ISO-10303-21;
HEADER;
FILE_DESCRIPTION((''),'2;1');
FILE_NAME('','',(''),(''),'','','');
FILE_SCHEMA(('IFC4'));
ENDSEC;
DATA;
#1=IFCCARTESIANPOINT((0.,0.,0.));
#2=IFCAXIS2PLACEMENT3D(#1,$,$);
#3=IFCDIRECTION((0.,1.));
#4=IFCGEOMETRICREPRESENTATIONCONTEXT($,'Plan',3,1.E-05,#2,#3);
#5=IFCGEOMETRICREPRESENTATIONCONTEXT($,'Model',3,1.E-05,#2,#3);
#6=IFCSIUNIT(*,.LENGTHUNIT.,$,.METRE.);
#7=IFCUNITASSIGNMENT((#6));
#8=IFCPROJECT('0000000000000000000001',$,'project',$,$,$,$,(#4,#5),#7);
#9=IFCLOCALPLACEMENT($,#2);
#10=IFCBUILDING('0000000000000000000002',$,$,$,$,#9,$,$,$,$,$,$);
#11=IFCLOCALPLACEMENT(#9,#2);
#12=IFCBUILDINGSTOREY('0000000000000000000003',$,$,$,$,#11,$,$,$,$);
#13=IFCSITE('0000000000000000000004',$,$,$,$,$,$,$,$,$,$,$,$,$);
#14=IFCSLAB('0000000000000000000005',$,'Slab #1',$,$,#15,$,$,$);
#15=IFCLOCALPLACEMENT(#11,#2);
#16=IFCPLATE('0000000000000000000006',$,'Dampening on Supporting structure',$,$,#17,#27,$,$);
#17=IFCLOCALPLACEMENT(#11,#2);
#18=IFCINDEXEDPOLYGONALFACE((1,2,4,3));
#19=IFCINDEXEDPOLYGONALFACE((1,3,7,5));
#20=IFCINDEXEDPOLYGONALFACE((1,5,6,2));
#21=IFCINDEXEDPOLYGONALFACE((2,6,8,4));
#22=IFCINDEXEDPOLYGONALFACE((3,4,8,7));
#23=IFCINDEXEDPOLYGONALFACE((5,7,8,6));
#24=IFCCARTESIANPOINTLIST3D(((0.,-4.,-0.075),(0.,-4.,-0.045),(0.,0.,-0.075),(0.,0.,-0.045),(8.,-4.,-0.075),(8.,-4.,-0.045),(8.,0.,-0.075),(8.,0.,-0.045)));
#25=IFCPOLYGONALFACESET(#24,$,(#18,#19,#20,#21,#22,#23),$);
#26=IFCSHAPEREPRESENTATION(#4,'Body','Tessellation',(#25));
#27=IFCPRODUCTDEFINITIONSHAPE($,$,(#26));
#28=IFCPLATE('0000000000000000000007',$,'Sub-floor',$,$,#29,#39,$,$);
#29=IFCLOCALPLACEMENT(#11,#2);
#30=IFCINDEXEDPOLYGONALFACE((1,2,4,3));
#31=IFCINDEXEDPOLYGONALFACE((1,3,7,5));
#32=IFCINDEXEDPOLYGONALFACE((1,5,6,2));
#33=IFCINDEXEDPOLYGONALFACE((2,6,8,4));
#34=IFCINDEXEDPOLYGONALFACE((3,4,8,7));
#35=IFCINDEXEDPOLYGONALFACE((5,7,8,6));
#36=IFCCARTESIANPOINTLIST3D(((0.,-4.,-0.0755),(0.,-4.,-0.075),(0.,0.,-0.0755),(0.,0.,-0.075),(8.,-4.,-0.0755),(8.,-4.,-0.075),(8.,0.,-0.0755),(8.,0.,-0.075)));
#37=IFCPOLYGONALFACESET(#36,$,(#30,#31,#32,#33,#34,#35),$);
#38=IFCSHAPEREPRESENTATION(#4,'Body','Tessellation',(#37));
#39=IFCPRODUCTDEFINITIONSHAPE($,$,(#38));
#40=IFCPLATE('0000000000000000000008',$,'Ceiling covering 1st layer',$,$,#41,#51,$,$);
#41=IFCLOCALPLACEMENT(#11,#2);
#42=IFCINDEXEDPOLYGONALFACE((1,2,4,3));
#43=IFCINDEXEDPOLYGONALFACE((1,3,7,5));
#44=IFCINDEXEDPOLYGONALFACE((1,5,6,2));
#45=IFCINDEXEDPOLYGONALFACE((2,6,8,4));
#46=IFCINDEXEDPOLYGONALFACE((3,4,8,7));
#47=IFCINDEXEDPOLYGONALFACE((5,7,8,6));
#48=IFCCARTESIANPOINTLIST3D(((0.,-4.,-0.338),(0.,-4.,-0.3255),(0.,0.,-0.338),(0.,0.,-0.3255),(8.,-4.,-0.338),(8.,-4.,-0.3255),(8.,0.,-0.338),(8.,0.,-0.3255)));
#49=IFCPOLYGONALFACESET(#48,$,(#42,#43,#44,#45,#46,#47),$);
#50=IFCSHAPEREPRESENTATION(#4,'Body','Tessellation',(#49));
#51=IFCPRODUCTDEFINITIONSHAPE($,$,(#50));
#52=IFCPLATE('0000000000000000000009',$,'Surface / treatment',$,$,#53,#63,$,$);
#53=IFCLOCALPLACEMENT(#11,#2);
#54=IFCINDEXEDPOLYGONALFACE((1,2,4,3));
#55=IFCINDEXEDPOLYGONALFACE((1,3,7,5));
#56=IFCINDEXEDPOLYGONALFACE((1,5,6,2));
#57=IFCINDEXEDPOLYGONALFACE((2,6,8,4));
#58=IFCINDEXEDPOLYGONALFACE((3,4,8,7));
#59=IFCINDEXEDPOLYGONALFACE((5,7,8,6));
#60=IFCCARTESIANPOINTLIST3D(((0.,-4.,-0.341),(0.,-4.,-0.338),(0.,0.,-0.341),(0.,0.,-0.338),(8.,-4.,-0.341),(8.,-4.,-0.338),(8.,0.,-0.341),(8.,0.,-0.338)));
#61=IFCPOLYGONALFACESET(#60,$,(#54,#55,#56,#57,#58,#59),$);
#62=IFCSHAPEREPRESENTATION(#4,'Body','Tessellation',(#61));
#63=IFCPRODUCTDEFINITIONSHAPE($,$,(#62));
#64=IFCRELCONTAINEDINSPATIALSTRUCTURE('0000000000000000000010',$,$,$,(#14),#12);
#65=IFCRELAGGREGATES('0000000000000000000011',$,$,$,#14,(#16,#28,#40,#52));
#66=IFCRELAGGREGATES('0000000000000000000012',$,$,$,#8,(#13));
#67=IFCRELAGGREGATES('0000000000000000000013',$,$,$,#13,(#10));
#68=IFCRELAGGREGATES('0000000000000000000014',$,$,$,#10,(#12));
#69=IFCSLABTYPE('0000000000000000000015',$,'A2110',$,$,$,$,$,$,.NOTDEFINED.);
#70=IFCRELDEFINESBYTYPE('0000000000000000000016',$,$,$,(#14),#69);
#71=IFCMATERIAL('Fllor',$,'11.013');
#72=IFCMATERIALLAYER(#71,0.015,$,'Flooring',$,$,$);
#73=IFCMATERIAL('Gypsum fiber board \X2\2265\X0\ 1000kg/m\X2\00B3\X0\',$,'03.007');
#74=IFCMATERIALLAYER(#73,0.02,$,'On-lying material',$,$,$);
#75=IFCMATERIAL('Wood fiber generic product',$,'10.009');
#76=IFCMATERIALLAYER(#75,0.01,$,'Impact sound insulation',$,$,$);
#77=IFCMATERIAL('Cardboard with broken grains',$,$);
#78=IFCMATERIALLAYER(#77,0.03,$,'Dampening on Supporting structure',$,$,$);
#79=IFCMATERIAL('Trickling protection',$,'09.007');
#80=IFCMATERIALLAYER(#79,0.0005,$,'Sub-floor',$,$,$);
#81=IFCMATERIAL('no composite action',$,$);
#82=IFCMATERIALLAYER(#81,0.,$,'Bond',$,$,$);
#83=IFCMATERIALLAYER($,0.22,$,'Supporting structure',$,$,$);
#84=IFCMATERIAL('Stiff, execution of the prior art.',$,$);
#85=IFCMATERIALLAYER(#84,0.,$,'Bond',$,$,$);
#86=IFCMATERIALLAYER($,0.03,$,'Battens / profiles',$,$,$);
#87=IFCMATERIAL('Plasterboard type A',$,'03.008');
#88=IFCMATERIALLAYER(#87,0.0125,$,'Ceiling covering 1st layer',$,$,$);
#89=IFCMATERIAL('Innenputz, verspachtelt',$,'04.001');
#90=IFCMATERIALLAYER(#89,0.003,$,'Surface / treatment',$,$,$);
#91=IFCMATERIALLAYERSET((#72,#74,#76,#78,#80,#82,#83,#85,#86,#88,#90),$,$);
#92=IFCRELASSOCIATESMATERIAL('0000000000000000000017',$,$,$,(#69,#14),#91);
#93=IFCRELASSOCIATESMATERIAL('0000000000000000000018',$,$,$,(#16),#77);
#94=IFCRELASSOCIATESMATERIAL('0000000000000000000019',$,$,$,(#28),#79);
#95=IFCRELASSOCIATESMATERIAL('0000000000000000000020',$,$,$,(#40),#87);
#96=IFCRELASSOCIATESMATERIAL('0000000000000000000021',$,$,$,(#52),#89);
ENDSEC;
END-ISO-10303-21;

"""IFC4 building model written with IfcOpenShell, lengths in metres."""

from ifc_helpers import new_model, si_unit, direction, frame, frame_2d, origin, place, context, project, spatial, rectangle, extrude, material, layer, layer_set, type_object, element, aggregate, save


model = new_model("IFC4")

# Units and contexts
plan_context = context("Plan", 3, precision=1e-05, world=origin(), true_north=direction((0.0, 1.0)))
model_context = context("Model", 3, precision=1e-05, world=origin(), true_north=direction((0.0, 1.0)))
ifc_project = project(units=[si_unit("LENGTHUNIT", "METRE")], contexts=[plan_context, model_context])

# Site, building, storey
site = spatial("IfcSite", under=ifc_project)
building_placement = place(None, origin())
building = spatial("IfcBuilding", under=site, at=building_placement)
storey_placement = place(building_placement, origin())
storey = spatial("IfcBuildingStorey", under=building, at=storey_placement)

# Slab, plates
ifc_material_1 = material(Name="Fllor", Category="11.013")
ifc_layer_1 = layer(ifc_material_1, 0.015, Name="Flooring")
ifc_material_2 = material(Name="Gypsum fiber board ≥ 1000kg/m³", Category="03.007")
ifc_layer_2 = layer(ifc_material_2, 0.02, Name="On-lying material")
ifc_material_3 = material(Name="Wood fiber generic product", Category="10.009")
ifc_layer_3 = layer(ifc_material_3, 0.01, Name="Impact sound insulation")
ifc_material_4 = material(Name="Cardboard with broken grains")
ifc_layer_4 = layer(ifc_material_4, 0.03, Name="Dampening on Supporting structure")
ifc_material_5 = material(Name="Trickling protection", Category="09.007")
ifc_layer_5 = layer(ifc_material_5, 0.0005, Name="Sub-floor")
ifc_material_6 = material(Name="no composite action")
ifc_layer_6 = layer(ifc_material_6, 0.0, Name="Bond")
ifc_layer_7 = layer(None, 0.22, Name="Supporting structure")
ifc_material_7 = material(Name="Stiff, execution of the prior art.")
ifc_layer_8 = layer(ifc_material_7, 0.0, Name="Bond")
ifc_layer_9 = layer(None, 0.03, Name="Battens / profiles")
ifc_material_8 = material(Name="Plasterboard type A", Category="03.008")
ifc_layer_10 = layer(ifc_material_8, 0.0125, Name="Ceiling covering 1st layer")
ifc_material_9 = material(Name="Innenputz, verspachtelt", Category="04.001")
ifc_layer_11 = layer(ifc_material_9, 0.003, Name="Surface / treatment")
ifc_layer_set = layer_set([ifc_layer_1, ifc_layer_2, ifc_layer_3, ifc_layer_4, ifc_layer_5, ifc_layer_6, ifc_layer_7, ifc_layer_8, ifc_layer_9, ifc_layer_10, ifc_layer_11])
slab_type = type_object("IfcSlabType", Name="A2110", PredefinedType="NOTDEFINED", material=ifc_layer_set)
slab_placement = place(None, frame((0.0, 0.0, 0.0), z_axis=(0.0, 0.0, -1.0), x_axis=(1.0, 0.0, 0.0)))
slab = element("IfcSlab", 1, at=slab_placement, inside=storey, type_object=slab_type, material=ifc_layer_set, Name="Slab #1")
plate_1_placement = place(slab_placement, origin())
plate_1 = element("IfcPlate", 2, at=plate_1_placement, material=ifc_material_4, Name="Dampening on Supporting structure", context=plan_context, shape_type="SweptSolid", body=[
    extrude(rectangle(XDim=8.0, YDim=4.0, at=frame_2d((4.0, 2.0), x_axis=(1.0, 0.0))), frame((0.0, 0.0, 0.045), z_axis=(0.0, 0.0, 1.0), x_axis=(1.0, 0.0, 0.0)), (0.0, 0.0, 1.0), 0.03),
])
plate_2_placement = place(slab_placement, origin())
plate_2 = element("IfcPlate", 3, at=plate_2_placement, material=ifc_material_5, Name="Sub-floor", context=plan_context, shape_type="SweptSolid", body=[
    extrude(rectangle(XDim=8.0, YDim=4.0, at=frame_2d((4.0, 2.0), x_axis=(1.0, 0.0))), frame((0.0, 0.0, 0.075), z_axis=(0.0, 0.0, 1.0), x_axis=(1.0, 0.0, 0.0)), (0.0, 0.0, 1.0), 0.0005),
])
plate_3_placement = place(slab_placement, origin())
plate_3 = element("IfcPlate", 4, at=plate_3_placement, material=ifc_material_8, Name="Ceiling covering 1st layer", context=plan_context, shape_type="SweptSolid", body=[
    extrude(rectangle(XDim=8.0, YDim=4.0, at=frame_2d((4.0, 2.0), x_axis=(1.0, 0.0))), frame((0.0, 0.0, 0.3255), z_axis=(0.0, 0.0, 1.0), x_axis=(1.0, 0.0, 0.0)), (0.0, 0.0, 1.0), 0.0125),
])
plate_4_placement = place(slab_placement, origin())
plate_4 = element("IfcPlate", 5, at=plate_4_placement, material=ifc_material_9, Name="Surface / treatment", context=plan_context, shape_type="SweptSolid", body=[
    extrude(rectangle(XDim=8.0, YDim=4.0, at=frame_2d((4.0, 2.0), x_axis=(1.0, 0.0))), frame((0.0, 0.0, 0.338), z_axis=(0.0, 0.0, 1.0), x_axis=(1.0, 0.0, 0.0)), (0.0, 0.0, 1.0), 0.003),
])
aggregate(slab, [plate_1, plate_2, plate_3, plate_4])

save(model, "model.ifc")
